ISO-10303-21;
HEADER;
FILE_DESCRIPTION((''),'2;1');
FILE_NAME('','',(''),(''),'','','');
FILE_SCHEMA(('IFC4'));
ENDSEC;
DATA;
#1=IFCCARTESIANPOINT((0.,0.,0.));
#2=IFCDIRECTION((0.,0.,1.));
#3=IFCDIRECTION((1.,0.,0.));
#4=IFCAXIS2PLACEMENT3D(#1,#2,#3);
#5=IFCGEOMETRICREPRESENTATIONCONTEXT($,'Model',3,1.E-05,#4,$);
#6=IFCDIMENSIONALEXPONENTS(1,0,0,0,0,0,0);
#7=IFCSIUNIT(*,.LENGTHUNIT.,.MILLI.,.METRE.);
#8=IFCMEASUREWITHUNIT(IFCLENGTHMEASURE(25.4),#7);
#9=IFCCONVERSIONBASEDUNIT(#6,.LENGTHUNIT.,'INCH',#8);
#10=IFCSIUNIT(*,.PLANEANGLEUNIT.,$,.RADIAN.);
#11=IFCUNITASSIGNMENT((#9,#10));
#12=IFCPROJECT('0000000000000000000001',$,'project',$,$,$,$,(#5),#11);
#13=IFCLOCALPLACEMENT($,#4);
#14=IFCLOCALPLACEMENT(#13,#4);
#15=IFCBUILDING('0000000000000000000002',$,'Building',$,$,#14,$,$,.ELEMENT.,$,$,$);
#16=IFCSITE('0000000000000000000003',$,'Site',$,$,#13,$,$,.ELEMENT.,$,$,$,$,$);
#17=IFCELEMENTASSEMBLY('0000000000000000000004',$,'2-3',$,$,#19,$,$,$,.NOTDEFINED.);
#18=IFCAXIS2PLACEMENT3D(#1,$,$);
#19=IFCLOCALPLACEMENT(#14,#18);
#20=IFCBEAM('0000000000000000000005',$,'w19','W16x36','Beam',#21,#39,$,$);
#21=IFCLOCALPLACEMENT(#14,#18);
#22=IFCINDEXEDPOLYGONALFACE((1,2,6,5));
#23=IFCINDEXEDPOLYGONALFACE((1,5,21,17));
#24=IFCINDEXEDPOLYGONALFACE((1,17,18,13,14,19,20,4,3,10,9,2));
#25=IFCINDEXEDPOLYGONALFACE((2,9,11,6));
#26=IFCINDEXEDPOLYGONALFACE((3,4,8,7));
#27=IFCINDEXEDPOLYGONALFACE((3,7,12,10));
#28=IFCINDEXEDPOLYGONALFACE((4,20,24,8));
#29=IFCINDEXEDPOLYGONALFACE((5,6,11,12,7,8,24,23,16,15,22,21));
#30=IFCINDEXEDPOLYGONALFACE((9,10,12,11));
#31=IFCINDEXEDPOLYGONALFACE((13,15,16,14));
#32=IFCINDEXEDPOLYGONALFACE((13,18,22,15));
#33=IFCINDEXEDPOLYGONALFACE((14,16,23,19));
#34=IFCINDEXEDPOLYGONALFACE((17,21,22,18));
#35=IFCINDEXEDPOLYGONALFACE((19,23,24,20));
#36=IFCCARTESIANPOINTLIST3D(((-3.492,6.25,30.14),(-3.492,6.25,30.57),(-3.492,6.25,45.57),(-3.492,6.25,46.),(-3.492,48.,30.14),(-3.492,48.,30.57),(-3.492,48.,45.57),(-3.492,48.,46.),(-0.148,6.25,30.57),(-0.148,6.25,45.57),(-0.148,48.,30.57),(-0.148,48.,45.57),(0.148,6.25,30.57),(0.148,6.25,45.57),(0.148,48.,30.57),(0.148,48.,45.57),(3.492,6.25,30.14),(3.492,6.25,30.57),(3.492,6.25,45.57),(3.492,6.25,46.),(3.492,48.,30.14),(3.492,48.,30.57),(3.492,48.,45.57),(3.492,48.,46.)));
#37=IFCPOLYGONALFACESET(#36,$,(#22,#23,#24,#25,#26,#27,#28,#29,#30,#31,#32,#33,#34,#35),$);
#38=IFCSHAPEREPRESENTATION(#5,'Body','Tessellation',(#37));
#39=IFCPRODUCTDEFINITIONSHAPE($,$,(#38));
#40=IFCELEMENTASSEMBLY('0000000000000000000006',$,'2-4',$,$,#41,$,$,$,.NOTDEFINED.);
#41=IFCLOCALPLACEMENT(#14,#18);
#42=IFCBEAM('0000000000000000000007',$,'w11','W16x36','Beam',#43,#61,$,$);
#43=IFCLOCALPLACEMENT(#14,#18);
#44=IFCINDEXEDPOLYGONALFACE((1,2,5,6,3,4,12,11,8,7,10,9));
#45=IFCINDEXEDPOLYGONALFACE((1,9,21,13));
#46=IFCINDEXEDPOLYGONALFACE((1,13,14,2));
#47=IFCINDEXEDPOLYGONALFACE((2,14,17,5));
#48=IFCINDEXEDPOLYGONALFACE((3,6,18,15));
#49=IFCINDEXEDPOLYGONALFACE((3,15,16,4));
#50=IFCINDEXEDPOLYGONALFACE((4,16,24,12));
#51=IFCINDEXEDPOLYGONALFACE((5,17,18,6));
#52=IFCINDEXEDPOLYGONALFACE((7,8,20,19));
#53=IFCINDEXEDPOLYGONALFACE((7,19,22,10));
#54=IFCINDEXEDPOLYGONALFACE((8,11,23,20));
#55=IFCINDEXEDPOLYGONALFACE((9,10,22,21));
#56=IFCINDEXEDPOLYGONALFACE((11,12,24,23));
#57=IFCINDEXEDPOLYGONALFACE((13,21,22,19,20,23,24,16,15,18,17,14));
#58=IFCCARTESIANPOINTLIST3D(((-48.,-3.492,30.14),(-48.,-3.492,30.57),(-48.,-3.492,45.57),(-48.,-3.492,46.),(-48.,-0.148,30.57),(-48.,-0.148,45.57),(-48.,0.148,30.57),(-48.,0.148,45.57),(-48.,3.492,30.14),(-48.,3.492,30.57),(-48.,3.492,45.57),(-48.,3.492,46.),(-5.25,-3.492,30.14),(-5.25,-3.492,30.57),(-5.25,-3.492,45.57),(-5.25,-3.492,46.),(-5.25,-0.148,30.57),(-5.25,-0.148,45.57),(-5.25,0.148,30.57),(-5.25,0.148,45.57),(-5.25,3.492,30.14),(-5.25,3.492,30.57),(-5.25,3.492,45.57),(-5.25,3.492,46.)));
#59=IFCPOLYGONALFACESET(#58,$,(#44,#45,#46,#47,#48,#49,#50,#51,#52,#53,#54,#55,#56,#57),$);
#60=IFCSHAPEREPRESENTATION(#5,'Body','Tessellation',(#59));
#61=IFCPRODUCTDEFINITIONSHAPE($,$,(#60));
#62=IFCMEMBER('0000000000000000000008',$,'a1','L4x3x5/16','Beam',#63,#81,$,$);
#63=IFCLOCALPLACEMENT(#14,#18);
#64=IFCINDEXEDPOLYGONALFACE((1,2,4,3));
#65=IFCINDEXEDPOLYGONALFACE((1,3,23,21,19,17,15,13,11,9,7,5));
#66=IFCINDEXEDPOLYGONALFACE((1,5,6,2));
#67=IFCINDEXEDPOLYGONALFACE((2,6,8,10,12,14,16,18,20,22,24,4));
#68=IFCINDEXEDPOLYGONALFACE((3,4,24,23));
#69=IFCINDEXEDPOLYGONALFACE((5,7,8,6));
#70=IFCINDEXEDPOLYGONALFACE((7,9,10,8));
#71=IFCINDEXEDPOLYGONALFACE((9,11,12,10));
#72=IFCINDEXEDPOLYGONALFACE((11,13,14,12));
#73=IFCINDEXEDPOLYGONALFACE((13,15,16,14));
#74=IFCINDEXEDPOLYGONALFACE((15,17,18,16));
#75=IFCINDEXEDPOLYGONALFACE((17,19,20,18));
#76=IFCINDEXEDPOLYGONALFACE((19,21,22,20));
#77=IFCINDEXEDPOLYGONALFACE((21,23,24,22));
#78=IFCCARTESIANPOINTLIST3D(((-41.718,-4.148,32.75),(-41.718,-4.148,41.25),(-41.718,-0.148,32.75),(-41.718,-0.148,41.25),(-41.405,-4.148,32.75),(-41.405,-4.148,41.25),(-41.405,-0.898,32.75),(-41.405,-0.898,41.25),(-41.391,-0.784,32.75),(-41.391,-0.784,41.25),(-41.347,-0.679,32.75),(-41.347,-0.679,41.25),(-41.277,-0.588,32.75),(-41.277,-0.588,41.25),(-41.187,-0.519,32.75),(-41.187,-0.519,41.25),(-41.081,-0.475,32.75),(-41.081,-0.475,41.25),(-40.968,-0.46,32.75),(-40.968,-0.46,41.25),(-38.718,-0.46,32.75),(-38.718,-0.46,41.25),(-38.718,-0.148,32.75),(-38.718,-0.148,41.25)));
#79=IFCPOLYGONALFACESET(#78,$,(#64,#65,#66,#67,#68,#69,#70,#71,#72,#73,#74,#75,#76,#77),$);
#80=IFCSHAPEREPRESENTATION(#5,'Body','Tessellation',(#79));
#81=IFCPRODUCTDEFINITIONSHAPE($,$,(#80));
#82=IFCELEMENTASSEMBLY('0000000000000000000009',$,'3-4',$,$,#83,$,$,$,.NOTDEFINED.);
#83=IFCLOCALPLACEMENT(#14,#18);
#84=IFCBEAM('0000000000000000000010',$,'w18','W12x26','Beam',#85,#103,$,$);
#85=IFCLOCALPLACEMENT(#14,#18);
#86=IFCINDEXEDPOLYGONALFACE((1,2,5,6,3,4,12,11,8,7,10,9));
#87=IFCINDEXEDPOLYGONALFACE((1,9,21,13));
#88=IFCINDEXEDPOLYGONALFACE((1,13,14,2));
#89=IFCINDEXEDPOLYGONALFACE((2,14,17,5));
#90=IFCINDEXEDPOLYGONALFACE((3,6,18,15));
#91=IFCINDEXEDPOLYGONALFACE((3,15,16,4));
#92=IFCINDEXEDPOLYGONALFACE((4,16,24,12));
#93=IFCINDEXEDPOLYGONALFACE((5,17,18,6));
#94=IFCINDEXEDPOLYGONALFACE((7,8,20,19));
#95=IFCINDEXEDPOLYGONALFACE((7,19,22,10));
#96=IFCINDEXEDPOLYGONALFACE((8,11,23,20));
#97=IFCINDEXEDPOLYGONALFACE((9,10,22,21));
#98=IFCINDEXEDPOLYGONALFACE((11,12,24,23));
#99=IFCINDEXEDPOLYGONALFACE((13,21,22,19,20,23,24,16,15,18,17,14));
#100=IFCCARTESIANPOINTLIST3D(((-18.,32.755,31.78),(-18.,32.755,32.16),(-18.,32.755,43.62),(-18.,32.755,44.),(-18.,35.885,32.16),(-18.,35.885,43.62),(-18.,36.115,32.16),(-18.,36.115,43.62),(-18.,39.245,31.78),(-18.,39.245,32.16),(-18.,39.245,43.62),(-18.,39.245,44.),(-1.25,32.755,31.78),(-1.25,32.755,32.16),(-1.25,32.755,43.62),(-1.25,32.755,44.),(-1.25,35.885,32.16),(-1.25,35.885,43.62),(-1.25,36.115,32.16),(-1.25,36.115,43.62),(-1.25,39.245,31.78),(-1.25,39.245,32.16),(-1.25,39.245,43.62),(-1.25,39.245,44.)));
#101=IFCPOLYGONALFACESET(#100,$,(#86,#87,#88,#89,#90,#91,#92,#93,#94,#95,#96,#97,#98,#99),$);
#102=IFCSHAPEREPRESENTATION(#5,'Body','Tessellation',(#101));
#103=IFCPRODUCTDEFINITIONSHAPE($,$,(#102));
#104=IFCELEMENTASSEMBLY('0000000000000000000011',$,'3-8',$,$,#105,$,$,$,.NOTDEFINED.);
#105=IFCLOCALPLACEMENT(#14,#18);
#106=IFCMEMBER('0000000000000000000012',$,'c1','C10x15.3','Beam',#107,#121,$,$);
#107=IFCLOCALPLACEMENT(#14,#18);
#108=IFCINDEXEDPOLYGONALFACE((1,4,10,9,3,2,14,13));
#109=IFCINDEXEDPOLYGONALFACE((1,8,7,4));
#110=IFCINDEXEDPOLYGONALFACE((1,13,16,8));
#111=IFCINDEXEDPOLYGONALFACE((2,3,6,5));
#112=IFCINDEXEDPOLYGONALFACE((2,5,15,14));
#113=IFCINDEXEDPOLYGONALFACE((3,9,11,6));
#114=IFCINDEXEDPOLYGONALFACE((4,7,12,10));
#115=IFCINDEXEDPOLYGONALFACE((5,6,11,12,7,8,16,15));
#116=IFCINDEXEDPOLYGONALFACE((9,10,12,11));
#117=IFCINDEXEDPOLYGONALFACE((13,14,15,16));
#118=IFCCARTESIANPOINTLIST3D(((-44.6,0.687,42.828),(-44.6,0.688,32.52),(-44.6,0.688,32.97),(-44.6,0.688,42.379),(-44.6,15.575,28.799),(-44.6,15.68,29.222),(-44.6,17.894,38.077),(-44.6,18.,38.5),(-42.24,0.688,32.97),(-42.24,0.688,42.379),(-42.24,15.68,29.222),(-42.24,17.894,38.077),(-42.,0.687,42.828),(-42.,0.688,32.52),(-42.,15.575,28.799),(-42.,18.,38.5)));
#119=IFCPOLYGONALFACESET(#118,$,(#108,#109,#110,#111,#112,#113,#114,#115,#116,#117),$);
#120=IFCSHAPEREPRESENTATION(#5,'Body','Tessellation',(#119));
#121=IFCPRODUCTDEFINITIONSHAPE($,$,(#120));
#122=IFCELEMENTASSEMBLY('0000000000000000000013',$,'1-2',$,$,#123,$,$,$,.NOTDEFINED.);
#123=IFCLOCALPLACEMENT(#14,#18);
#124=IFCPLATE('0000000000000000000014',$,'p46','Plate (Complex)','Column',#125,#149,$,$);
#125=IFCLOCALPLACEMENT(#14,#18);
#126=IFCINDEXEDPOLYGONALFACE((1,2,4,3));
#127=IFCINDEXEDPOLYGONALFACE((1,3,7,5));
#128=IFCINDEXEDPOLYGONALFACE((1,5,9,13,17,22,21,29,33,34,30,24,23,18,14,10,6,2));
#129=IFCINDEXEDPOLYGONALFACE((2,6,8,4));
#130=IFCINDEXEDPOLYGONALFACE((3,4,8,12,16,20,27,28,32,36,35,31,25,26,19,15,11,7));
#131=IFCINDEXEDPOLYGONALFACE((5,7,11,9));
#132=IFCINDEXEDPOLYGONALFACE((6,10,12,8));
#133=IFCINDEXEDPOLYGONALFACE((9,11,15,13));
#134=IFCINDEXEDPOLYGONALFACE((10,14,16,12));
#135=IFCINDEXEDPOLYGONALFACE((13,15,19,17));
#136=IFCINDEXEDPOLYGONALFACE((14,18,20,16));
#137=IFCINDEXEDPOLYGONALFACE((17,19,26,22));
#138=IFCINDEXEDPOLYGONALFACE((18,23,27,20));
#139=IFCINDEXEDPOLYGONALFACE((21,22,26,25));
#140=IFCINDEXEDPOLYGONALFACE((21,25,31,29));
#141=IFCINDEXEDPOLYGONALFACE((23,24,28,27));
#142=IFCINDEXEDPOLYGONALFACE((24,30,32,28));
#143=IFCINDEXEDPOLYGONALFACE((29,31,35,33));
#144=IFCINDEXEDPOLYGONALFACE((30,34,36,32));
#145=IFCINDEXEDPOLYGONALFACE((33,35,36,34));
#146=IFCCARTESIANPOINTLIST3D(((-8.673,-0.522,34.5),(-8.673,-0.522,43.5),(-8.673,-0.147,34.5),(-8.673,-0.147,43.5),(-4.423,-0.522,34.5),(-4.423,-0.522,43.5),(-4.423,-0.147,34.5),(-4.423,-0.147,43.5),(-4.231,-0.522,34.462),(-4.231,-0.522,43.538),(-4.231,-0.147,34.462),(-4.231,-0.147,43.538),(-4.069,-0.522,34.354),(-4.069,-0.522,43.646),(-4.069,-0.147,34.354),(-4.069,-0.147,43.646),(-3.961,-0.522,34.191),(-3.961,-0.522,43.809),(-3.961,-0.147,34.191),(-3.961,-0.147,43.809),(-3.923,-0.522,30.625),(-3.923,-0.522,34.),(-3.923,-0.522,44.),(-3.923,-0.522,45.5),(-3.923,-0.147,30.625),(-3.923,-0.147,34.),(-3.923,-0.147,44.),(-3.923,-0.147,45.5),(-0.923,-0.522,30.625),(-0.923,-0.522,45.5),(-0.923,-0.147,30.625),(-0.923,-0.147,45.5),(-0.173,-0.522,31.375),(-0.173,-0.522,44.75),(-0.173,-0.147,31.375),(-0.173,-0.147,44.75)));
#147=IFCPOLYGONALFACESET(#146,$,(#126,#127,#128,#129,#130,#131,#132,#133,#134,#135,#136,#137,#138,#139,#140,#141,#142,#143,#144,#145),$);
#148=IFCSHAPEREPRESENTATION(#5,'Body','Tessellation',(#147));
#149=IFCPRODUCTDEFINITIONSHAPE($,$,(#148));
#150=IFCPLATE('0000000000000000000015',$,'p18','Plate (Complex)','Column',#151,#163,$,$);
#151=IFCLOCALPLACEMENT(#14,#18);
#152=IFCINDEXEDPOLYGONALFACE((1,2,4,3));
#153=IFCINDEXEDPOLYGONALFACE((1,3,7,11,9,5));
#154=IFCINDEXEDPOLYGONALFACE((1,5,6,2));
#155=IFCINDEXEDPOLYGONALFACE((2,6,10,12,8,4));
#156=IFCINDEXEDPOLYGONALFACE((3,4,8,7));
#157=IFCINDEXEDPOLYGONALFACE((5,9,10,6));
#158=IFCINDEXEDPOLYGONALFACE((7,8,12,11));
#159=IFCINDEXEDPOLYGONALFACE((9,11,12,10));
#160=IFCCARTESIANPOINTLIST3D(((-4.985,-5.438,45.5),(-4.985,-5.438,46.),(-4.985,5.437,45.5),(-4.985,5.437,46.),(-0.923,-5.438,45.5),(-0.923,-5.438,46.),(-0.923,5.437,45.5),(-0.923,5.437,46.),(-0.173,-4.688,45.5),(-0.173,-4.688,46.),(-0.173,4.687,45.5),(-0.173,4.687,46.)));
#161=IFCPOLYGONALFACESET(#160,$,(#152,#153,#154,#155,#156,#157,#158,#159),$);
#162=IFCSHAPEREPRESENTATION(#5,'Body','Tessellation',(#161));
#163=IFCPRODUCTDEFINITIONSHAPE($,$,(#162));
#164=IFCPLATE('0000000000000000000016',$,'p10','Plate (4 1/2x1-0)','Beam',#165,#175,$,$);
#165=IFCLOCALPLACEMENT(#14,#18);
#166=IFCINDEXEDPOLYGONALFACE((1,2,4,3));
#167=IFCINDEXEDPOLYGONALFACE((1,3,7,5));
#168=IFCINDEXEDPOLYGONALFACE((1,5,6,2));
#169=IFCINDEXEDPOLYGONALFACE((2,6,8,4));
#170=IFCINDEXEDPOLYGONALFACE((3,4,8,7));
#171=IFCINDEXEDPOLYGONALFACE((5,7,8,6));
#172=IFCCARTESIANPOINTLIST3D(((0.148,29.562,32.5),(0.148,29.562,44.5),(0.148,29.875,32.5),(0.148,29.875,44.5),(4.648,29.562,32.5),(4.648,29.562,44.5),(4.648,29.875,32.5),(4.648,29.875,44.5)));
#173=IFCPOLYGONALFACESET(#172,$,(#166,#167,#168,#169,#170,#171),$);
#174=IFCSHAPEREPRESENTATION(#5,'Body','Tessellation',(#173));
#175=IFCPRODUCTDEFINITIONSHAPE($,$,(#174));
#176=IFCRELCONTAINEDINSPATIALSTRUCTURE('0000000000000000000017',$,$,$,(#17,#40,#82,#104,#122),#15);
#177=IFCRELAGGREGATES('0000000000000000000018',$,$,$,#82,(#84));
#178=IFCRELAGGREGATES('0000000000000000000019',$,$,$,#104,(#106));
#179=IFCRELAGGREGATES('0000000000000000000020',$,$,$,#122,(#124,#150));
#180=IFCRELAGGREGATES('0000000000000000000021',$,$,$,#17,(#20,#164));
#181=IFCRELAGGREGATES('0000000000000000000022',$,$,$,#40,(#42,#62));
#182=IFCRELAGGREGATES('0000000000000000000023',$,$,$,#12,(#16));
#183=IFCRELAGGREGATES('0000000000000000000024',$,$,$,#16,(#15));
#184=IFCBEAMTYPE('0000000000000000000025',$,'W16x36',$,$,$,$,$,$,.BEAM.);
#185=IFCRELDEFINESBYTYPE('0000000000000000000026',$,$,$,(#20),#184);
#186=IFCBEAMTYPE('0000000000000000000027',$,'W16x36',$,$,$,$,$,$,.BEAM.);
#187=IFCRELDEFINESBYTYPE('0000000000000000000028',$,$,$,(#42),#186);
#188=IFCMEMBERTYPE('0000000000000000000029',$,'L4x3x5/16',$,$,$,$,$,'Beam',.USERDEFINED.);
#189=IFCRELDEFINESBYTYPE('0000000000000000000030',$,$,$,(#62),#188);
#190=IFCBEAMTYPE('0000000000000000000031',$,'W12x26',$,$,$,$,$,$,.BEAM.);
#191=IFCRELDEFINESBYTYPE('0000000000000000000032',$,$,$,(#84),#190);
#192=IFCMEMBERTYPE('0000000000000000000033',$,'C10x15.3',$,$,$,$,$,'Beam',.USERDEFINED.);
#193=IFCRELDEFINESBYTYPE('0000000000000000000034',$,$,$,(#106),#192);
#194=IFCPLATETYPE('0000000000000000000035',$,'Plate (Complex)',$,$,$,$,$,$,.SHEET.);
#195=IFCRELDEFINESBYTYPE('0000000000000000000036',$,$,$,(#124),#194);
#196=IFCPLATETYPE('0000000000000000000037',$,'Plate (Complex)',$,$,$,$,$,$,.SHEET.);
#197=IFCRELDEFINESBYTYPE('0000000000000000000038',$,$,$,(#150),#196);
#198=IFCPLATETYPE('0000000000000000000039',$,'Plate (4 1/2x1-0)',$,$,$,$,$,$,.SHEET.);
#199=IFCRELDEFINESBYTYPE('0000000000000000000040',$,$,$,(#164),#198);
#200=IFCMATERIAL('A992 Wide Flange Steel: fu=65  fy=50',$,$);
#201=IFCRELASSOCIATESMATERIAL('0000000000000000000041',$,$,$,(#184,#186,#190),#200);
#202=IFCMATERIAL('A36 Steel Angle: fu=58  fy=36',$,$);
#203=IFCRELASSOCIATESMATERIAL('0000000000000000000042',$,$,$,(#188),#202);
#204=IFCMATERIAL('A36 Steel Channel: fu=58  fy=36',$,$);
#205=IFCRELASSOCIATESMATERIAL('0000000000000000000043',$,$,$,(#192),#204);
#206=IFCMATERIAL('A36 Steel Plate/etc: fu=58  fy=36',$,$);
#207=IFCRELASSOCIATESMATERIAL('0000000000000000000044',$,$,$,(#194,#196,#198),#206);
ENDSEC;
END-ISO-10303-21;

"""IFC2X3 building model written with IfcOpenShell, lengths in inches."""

from ifc_helpers import new_model, entity, si_unit, converted_unit, frame, frame_2d, origin_with_axes, place, context, project, spatial, polyline, i_section, l_section, u_section, outline, extrude, clip, halfspace, source, transform, mapped, material, type_object, type_shapes, element, aggregate, save


model = new_model("IFC2X3")

# Units and contexts
model_context = context("Model", 3, precision=1e-05, world=origin_with_axes())
ifc_project = project(units=[converted_unit("LENGTHUNIT", "INCH", entity("IfcLengthMeasure", 25.4), si_unit("LENGTHUNIT", "METRE", prefix="MILLI"), dimensions=[1, 0, 0, 0, 0, 0, 0]), si_unit("PLANEANGLEUNIT", "RADIAN")], contexts=[model_context])

# Site, building
site_placement = place(None, origin_with_axes())
site = spatial("IfcSite", under=ifc_project, at=site_placement, Name="Site", CompositionType="ELEMENT")
building_placement = place(site_placement, origin_with_axes())
building = spatial("IfcBuilding", under=site, at=building_placement, Name="Building", CompositionType="ELEMENT")

# Element assembly, beam
assembly_1_placement = place(building_placement, frame((0.0, 0.0, 46.0), z_axis=(0.0, 0.0, 1.0), x_axis=(0.0, 1.0, 0.0)))
assembly_1 = element("IfcElementAssembly", 1, at=assembly_1_placement, inside=building, Name="2-3", PredefinedType="NOTDEFINED")
ifc_material_1 = material(Name="A992 Wide Flange Steel: fu=65  fy=50")
beam_type_1 = type_object("IfcBeamType", Name="W16x36", PredefinedType="BEAM", material=ifc_material_1)
shared_shape_1 = source(origin_with_axes(), model_context, "Body", "SweptSolid", [
    extrude(i_section(OverallWidth=6.985, OverallDepth=15.86, WebThickness=0.295, FlangeThickness=0.43, at=frame_2d((0.0, -7.93), x_axis=(1.0, 0.0))), frame((0.0, 0.0, 0.0), z_axis=(1.0, 0.0, 0.0), x_axis=(0.0, 1.0, 0.0)), (0.0, 0.0, 1.0), 41.75),
])
type_shapes(beam_type_1, [shared_shape_1])
beam_1_placement = place(assembly_1_placement, frame((6.25, 0.0, 0.0), z_axis=(0.0, 0.0, 1.0), x_axis=(1.0, 0.0, 0.0)))
beam_1 = element("IfcBeam", 2, at=beam_1_placement, type_object=beam_type_1, Name="w19", Description="W16x36", ObjectType="Beam", context=model_context, shape_type="MappedRepresentation", body=[
    mapped(shared_shape_1, transform((0.0, 0.0, 0.0), scale=1.0)),
])

# Element assembly, beam, member
assembly_2_placement = place(building_placement, frame((0.0, 0.0, 46.0), z_axis=(0.0, 0.0, 1.0), x_axis=(-1.0, 0.0, 0.0)))
assembly_2 = element("IfcElementAssembly", 3, at=assembly_2_placement, inside=building, Name="2-4", PredefinedType="NOTDEFINED")
beam_type_2 = type_object("IfcBeamType", Name="W16x36", PredefinedType="BEAM", material=ifc_material_1)
shared_shape_2 = source(origin_with_axes(), model_context, "Body", "SweptSolid", [
    extrude(i_section(OverallWidth=6.985, OverallDepth=15.86, WebThickness=0.295, FlangeThickness=0.43, at=frame_2d((0.0, -7.93), x_axis=(1.0, 0.0))), frame((0.0, 0.0, 0.0), z_axis=(1.0, 0.0, 0.0), x_axis=(0.0, 1.0, 0.0)), (0.0, 0.0, 1.0), 42.75),
])
type_shapes(beam_type_2, [shared_shape_2])
beam_2_placement = place(assembly_2_placement, frame((5.25, 0.0, 0.0), z_axis=(0.0, 0.0, 1.0), x_axis=(1.0, 0.0, 0.0)))
beam_2 = element("IfcBeam", 4, at=beam_2_placement, type_object=beam_type_2, Name="w11", Description="W16x36", ObjectType="Beam", context=model_context, shape_type="MappedRepresentation", body=[
    mapped(shared_shape_2, transform((0.0, 0.0, 0.0), scale=1.0)),
])
ifc_material_2 = material(Name="A36 Steel Angle: fu=58  fy=36")
member_type_1 = type_object("IfcMemberType", Name="L4x3x5/16", ElementType="Beam", PredefinedType="USERDEFINED", material=ifc_material_2)
shared_shape_3 = source(origin_with_axes(), model_context, "Body", "SweptSolid", [
    extrude(l_section(Depth=4.0, Width=3.0, Thickness=0.312, FilletRadius=0.438, at=frame_2d((1.5, 2.0), x_axis=(1.0, 0.0))), frame((0.0, 0.0, 0.0), z_axis=(1.0, 0.0, 0.0), x_axis=(0.0, 1.0, 0.0)), (0.0, 0.0, 1.0), 8.5),
])
type_shapes(member_type_1, [shared_shape_3])
member_1_placement = place(assembly_2_placement, frame((41.718, 0.148, -4.75), z_axis=(0.0, 1.0, 0.0), x_axis=(0.0, 0.0, -1.0)))
member_1 = element("IfcMember", 5, at=member_1_placement, type_object=member_type_1, Name="a1", Description="L4x3x5/16", ObjectType="Beam", context=model_context, shape_type="MappedRepresentation", body=[
    mapped(shared_shape_3, transform((0.0, 0.0, 0.0), scale=1.0)),
])

# Element assembly, beam
assembly_3_placement = place(building_placement, frame((0.0, 36.0, 44.0), z_axis=(0.0, 0.0, 1.0), x_axis=(-1.0, 0.0, 0.0)))
assembly_3 = element("IfcElementAssembly", 6, at=assembly_3_placement, inside=building, Name="3-4", PredefinedType="NOTDEFINED")
beam_type_3 = type_object("IfcBeamType", Name="W12x26", PredefinedType="BEAM", material=ifc_material_1)
shared_shape_4 = source(origin_with_axes(), model_context, "Body", "SweptSolid", [
    extrude(i_section(OverallWidth=6.49, OverallDepth=12.22, WebThickness=0.23, FlangeThickness=0.38, at=frame_2d((0.0, -6.11), x_axis=(1.0, 0.0))), frame((0.0, 0.0, 0.0), z_axis=(1.0, 0.0, 0.0), x_axis=(0.0, 1.0, 0.0)), (0.0, 0.0, 1.0), 16.75),
])
type_shapes(beam_type_3, [shared_shape_4])
beam_3_placement = place(assembly_3_placement, frame((1.25, 0.0, 0.0), z_axis=(0.0, 0.0, 1.0), x_axis=(1.0, 0.0, 0.0)))
beam_3 = element("IfcBeam", 7, at=beam_3_placement, type_object=beam_type_3, Name="w18", Description="W12x26", ObjectType="Beam", context=model_context, shape_type="MappedRepresentation", body=[
    mapped(shared_shape_4, transform((0.0, 0.0, 0.0), scale=1.0)),
])
aggregate(assembly_3, [beam_3])

# Element assembly, member
assembly_4_placement = place(building_placement, frame((-42.0, 0.0, 43.0), z_axis=(0.0, 0.242536, 0.970142), x_axis=(0.0, 0.970142, -0.242536)))
assembly_4 = element("IfcElementAssembly", 8, at=assembly_4_placement, inside=building, Name="3-8", PredefinedType="NOTDEFINED")
ifc_material_3 = material(Name="A36 Steel Channel: fu=58  fy=36")
member_type_2 = type_object("IfcMemberType", Name="C10x15.3", ElementType="Beam", PredefinedType="USERDEFINED", material=ifc_material_3)
shared_shape_5 = source(origin_with_axes(), model_context, "Body", "Clipping", [
    clip(extrude(u_section(Depth=10.0, FlangeWidth=2.6, WebThickness=0.24, FlangeThickness=0.436, at=frame_2d((1.3, -5.0), x_axis=(1.0, 0.0))), frame((0.0, 0.0, 0.0), z_axis=(1.0, 0.0, 0.0), x_axis=(0.0, 1.0, 0.0)), (0.0, 0.0, 1.0), 17.845), halfspace(frame((0.0, 0.0, 0.0), z_axis=(-0.97013, 0.0, -0.2426), x_axis=(-0.2426, 0.0, 0.97013)), False)),
])
type_shapes(member_type_2, [shared_shape_5])
member_2_placement = place(assembly_4_placement, frame((0.709, 0.0, 0.0), z_axis=(0.0, 0.0, 1.0), x_axis=(1.0, 0.0, 0.0)))
member_2 = element("IfcMember", 9, at=member_2_placement, type_object=member_type_2, Name="c1", Description="C10x15.3", ObjectType="Beam", context=model_context, shape_type="MappedRepresentation", body=[
    mapped(shared_shape_5, transform((0.0, 0.0, 0.0), scale=1.0)),
])
aggregate(assembly_4, [member_2])

# Element assembly, plates
assembly_5_placement = place(building_placement, frame((0.0, 0.0, 21.0), z_axis=(0.0, -1.0, 0.0), x_axis=(0.0, 0.0, 1.0)))
assembly_5 = element("IfcElementAssembly", 10, at=assembly_5_placement, inside=building, Name="1-2", PredefinedType="NOTDEFINED")
ifc_material_4 = material(Name="A36 Steel Plate/etc: fu=58  fy=36")
plate_type_1 = type_object("IfcPlateType", Name="Plate (Complex)", PredefinedType="SHEET", material=ifc_material_4)
shared_shape_6 = source(origin_with_axes(), model_context, "Body", "SweptSolid", [
    extrude(outline(polyline([(0.0, -3.75), (-1.5, -3.75), (-1.691, -3.788), (-1.854, -3.896), (-1.962, -4.059), (-2.0, -4.25), (-2.0, -8.5), (-11.0, -8.5), (-11.0, -4.25), (-11.038, -4.059), (-11.146, -3.896), (-11.309, -3.788), (-11.5, -3.75), (-14.875, -3.75), (-14.875, -0.75), (-14.125, 0.0), (-0.75, 0.0), (0.0, -0.75), (0.0, -3.75)])), frame((-0.188, 0.0, 0.0), z_axis=(1.0, 0.0, 0.0), x_axis=(0.0, 1.0, 0.0)), (0.0, 0.0, 1.0), 0.375),
])
type_shapes(plate_type_1, [shared_shape_6])
plate_1_placement = place(assembly_5_placement, frame((24.5, 0.173, 0.335), z_axis=(0.0, -1.0, 0.0), x_axis=(0.0, 0.0, -1.0)))
plate_1 = element("IfcPlate", 11, at=plate_1_placement, type_object=plate_type_1, Name="p46", Description="Plate (Complex)", ObjectType="Column", context=model_context, shape_type="MappedRepresentation", body=[
    mapped(shared_shape_6, transform((0.0, 0.0, 0.0), scale=1.0)),
])
plate_type_2 = type_object("IfcPlateType", Name="Plate (Complex)", PredefinedType="SHEET", material=ifc_material_4)
shared_shape_7 = source(origin_with_axes(), model_context, "Body", "SweptSolid", [
    extrude(outline(polyline([(5.438, -4.812), (-5.438, -4.812), (-5.438, -0.75), (-4.688, 0.0), (4.688, 0.0), (5.438, -0.75), (5.438, -4.812)])), frame((-0.25, 0.0, 0.0), z_axis=(1.0, 0.0, 0.0), x_axis=(0.0, 1.0, 0.0)), (0.0, 0.0, 1.0), 0.5),
])
type_shapes(plate_type_2, [shared_shape_7])
plate_2_placement = place(assembly_5_placement, frame((24.75, 0.173, 0.0), z_axis=(0.0, -1.0, 0.0), x_axis=(1.0, 0.0, 0.0)))
plate_2 = element("IfcPlate", 12, at=plate_2_placement, type_object=plate_type_2, Name="p18", Description="Plate (Complex)", ObjectType="Column", context=model_context, shape_type="MappedRepresentation", body=[
    mapped(shared_shape_7, transform((0.0, 0.0, 0.0), scale=1.0)),
])
aggregate(assembly_5, [plate_1, plate_2])

# Plate
plate_type_3 = type_object("IfcPlateType", Name="Plate (4 1/2x1-0)", PredefinedType="SHEET", material=ifc_material_4)
shared_shape_8 = source(origin_with_axes(), model_context, "Body", "SweptSolid", [
    extrude(outline(polyline([(0.0, -4.5), (-12.0, -4.5), (-12.0, 0.0), (0.0, 0.0), (0.0, -4.5)])), frame((-0.156, 0.0, 0.0), z_axis=(1.0, 0.0, 0.0), x_axis=(0.0, 1.0, 0.0)), (0.0, 0.0, 1.0), 0.312),
])
type_shapes(plate_type_3, [shared_shape_8])
plate_3_placement = place(assembly_1_placement, frame((29.719, -0.148, -1.5), z_axis=(0.0, 1.0, 0.0), x_axis=(-1.0, 0.0, 0.0)))
plate_3 = element("IfcPlate", 13, at=plate_3_placement, type_object=plate_type_3, Name="p10", Description="Plate (4 1/2x1-0)", ObjectType="Beam", context=model_context, shape_type="MappedRepresentation", body=[
    mapped(shared_shape_8, transform((0.0, 0.0, 0.0), scale=1.0)),
])
aggregate(assembly_1, [beam_1, plate_3])
aggregate(assembly_2, [beam_2, member_1])

save(model, "model.ifc")
